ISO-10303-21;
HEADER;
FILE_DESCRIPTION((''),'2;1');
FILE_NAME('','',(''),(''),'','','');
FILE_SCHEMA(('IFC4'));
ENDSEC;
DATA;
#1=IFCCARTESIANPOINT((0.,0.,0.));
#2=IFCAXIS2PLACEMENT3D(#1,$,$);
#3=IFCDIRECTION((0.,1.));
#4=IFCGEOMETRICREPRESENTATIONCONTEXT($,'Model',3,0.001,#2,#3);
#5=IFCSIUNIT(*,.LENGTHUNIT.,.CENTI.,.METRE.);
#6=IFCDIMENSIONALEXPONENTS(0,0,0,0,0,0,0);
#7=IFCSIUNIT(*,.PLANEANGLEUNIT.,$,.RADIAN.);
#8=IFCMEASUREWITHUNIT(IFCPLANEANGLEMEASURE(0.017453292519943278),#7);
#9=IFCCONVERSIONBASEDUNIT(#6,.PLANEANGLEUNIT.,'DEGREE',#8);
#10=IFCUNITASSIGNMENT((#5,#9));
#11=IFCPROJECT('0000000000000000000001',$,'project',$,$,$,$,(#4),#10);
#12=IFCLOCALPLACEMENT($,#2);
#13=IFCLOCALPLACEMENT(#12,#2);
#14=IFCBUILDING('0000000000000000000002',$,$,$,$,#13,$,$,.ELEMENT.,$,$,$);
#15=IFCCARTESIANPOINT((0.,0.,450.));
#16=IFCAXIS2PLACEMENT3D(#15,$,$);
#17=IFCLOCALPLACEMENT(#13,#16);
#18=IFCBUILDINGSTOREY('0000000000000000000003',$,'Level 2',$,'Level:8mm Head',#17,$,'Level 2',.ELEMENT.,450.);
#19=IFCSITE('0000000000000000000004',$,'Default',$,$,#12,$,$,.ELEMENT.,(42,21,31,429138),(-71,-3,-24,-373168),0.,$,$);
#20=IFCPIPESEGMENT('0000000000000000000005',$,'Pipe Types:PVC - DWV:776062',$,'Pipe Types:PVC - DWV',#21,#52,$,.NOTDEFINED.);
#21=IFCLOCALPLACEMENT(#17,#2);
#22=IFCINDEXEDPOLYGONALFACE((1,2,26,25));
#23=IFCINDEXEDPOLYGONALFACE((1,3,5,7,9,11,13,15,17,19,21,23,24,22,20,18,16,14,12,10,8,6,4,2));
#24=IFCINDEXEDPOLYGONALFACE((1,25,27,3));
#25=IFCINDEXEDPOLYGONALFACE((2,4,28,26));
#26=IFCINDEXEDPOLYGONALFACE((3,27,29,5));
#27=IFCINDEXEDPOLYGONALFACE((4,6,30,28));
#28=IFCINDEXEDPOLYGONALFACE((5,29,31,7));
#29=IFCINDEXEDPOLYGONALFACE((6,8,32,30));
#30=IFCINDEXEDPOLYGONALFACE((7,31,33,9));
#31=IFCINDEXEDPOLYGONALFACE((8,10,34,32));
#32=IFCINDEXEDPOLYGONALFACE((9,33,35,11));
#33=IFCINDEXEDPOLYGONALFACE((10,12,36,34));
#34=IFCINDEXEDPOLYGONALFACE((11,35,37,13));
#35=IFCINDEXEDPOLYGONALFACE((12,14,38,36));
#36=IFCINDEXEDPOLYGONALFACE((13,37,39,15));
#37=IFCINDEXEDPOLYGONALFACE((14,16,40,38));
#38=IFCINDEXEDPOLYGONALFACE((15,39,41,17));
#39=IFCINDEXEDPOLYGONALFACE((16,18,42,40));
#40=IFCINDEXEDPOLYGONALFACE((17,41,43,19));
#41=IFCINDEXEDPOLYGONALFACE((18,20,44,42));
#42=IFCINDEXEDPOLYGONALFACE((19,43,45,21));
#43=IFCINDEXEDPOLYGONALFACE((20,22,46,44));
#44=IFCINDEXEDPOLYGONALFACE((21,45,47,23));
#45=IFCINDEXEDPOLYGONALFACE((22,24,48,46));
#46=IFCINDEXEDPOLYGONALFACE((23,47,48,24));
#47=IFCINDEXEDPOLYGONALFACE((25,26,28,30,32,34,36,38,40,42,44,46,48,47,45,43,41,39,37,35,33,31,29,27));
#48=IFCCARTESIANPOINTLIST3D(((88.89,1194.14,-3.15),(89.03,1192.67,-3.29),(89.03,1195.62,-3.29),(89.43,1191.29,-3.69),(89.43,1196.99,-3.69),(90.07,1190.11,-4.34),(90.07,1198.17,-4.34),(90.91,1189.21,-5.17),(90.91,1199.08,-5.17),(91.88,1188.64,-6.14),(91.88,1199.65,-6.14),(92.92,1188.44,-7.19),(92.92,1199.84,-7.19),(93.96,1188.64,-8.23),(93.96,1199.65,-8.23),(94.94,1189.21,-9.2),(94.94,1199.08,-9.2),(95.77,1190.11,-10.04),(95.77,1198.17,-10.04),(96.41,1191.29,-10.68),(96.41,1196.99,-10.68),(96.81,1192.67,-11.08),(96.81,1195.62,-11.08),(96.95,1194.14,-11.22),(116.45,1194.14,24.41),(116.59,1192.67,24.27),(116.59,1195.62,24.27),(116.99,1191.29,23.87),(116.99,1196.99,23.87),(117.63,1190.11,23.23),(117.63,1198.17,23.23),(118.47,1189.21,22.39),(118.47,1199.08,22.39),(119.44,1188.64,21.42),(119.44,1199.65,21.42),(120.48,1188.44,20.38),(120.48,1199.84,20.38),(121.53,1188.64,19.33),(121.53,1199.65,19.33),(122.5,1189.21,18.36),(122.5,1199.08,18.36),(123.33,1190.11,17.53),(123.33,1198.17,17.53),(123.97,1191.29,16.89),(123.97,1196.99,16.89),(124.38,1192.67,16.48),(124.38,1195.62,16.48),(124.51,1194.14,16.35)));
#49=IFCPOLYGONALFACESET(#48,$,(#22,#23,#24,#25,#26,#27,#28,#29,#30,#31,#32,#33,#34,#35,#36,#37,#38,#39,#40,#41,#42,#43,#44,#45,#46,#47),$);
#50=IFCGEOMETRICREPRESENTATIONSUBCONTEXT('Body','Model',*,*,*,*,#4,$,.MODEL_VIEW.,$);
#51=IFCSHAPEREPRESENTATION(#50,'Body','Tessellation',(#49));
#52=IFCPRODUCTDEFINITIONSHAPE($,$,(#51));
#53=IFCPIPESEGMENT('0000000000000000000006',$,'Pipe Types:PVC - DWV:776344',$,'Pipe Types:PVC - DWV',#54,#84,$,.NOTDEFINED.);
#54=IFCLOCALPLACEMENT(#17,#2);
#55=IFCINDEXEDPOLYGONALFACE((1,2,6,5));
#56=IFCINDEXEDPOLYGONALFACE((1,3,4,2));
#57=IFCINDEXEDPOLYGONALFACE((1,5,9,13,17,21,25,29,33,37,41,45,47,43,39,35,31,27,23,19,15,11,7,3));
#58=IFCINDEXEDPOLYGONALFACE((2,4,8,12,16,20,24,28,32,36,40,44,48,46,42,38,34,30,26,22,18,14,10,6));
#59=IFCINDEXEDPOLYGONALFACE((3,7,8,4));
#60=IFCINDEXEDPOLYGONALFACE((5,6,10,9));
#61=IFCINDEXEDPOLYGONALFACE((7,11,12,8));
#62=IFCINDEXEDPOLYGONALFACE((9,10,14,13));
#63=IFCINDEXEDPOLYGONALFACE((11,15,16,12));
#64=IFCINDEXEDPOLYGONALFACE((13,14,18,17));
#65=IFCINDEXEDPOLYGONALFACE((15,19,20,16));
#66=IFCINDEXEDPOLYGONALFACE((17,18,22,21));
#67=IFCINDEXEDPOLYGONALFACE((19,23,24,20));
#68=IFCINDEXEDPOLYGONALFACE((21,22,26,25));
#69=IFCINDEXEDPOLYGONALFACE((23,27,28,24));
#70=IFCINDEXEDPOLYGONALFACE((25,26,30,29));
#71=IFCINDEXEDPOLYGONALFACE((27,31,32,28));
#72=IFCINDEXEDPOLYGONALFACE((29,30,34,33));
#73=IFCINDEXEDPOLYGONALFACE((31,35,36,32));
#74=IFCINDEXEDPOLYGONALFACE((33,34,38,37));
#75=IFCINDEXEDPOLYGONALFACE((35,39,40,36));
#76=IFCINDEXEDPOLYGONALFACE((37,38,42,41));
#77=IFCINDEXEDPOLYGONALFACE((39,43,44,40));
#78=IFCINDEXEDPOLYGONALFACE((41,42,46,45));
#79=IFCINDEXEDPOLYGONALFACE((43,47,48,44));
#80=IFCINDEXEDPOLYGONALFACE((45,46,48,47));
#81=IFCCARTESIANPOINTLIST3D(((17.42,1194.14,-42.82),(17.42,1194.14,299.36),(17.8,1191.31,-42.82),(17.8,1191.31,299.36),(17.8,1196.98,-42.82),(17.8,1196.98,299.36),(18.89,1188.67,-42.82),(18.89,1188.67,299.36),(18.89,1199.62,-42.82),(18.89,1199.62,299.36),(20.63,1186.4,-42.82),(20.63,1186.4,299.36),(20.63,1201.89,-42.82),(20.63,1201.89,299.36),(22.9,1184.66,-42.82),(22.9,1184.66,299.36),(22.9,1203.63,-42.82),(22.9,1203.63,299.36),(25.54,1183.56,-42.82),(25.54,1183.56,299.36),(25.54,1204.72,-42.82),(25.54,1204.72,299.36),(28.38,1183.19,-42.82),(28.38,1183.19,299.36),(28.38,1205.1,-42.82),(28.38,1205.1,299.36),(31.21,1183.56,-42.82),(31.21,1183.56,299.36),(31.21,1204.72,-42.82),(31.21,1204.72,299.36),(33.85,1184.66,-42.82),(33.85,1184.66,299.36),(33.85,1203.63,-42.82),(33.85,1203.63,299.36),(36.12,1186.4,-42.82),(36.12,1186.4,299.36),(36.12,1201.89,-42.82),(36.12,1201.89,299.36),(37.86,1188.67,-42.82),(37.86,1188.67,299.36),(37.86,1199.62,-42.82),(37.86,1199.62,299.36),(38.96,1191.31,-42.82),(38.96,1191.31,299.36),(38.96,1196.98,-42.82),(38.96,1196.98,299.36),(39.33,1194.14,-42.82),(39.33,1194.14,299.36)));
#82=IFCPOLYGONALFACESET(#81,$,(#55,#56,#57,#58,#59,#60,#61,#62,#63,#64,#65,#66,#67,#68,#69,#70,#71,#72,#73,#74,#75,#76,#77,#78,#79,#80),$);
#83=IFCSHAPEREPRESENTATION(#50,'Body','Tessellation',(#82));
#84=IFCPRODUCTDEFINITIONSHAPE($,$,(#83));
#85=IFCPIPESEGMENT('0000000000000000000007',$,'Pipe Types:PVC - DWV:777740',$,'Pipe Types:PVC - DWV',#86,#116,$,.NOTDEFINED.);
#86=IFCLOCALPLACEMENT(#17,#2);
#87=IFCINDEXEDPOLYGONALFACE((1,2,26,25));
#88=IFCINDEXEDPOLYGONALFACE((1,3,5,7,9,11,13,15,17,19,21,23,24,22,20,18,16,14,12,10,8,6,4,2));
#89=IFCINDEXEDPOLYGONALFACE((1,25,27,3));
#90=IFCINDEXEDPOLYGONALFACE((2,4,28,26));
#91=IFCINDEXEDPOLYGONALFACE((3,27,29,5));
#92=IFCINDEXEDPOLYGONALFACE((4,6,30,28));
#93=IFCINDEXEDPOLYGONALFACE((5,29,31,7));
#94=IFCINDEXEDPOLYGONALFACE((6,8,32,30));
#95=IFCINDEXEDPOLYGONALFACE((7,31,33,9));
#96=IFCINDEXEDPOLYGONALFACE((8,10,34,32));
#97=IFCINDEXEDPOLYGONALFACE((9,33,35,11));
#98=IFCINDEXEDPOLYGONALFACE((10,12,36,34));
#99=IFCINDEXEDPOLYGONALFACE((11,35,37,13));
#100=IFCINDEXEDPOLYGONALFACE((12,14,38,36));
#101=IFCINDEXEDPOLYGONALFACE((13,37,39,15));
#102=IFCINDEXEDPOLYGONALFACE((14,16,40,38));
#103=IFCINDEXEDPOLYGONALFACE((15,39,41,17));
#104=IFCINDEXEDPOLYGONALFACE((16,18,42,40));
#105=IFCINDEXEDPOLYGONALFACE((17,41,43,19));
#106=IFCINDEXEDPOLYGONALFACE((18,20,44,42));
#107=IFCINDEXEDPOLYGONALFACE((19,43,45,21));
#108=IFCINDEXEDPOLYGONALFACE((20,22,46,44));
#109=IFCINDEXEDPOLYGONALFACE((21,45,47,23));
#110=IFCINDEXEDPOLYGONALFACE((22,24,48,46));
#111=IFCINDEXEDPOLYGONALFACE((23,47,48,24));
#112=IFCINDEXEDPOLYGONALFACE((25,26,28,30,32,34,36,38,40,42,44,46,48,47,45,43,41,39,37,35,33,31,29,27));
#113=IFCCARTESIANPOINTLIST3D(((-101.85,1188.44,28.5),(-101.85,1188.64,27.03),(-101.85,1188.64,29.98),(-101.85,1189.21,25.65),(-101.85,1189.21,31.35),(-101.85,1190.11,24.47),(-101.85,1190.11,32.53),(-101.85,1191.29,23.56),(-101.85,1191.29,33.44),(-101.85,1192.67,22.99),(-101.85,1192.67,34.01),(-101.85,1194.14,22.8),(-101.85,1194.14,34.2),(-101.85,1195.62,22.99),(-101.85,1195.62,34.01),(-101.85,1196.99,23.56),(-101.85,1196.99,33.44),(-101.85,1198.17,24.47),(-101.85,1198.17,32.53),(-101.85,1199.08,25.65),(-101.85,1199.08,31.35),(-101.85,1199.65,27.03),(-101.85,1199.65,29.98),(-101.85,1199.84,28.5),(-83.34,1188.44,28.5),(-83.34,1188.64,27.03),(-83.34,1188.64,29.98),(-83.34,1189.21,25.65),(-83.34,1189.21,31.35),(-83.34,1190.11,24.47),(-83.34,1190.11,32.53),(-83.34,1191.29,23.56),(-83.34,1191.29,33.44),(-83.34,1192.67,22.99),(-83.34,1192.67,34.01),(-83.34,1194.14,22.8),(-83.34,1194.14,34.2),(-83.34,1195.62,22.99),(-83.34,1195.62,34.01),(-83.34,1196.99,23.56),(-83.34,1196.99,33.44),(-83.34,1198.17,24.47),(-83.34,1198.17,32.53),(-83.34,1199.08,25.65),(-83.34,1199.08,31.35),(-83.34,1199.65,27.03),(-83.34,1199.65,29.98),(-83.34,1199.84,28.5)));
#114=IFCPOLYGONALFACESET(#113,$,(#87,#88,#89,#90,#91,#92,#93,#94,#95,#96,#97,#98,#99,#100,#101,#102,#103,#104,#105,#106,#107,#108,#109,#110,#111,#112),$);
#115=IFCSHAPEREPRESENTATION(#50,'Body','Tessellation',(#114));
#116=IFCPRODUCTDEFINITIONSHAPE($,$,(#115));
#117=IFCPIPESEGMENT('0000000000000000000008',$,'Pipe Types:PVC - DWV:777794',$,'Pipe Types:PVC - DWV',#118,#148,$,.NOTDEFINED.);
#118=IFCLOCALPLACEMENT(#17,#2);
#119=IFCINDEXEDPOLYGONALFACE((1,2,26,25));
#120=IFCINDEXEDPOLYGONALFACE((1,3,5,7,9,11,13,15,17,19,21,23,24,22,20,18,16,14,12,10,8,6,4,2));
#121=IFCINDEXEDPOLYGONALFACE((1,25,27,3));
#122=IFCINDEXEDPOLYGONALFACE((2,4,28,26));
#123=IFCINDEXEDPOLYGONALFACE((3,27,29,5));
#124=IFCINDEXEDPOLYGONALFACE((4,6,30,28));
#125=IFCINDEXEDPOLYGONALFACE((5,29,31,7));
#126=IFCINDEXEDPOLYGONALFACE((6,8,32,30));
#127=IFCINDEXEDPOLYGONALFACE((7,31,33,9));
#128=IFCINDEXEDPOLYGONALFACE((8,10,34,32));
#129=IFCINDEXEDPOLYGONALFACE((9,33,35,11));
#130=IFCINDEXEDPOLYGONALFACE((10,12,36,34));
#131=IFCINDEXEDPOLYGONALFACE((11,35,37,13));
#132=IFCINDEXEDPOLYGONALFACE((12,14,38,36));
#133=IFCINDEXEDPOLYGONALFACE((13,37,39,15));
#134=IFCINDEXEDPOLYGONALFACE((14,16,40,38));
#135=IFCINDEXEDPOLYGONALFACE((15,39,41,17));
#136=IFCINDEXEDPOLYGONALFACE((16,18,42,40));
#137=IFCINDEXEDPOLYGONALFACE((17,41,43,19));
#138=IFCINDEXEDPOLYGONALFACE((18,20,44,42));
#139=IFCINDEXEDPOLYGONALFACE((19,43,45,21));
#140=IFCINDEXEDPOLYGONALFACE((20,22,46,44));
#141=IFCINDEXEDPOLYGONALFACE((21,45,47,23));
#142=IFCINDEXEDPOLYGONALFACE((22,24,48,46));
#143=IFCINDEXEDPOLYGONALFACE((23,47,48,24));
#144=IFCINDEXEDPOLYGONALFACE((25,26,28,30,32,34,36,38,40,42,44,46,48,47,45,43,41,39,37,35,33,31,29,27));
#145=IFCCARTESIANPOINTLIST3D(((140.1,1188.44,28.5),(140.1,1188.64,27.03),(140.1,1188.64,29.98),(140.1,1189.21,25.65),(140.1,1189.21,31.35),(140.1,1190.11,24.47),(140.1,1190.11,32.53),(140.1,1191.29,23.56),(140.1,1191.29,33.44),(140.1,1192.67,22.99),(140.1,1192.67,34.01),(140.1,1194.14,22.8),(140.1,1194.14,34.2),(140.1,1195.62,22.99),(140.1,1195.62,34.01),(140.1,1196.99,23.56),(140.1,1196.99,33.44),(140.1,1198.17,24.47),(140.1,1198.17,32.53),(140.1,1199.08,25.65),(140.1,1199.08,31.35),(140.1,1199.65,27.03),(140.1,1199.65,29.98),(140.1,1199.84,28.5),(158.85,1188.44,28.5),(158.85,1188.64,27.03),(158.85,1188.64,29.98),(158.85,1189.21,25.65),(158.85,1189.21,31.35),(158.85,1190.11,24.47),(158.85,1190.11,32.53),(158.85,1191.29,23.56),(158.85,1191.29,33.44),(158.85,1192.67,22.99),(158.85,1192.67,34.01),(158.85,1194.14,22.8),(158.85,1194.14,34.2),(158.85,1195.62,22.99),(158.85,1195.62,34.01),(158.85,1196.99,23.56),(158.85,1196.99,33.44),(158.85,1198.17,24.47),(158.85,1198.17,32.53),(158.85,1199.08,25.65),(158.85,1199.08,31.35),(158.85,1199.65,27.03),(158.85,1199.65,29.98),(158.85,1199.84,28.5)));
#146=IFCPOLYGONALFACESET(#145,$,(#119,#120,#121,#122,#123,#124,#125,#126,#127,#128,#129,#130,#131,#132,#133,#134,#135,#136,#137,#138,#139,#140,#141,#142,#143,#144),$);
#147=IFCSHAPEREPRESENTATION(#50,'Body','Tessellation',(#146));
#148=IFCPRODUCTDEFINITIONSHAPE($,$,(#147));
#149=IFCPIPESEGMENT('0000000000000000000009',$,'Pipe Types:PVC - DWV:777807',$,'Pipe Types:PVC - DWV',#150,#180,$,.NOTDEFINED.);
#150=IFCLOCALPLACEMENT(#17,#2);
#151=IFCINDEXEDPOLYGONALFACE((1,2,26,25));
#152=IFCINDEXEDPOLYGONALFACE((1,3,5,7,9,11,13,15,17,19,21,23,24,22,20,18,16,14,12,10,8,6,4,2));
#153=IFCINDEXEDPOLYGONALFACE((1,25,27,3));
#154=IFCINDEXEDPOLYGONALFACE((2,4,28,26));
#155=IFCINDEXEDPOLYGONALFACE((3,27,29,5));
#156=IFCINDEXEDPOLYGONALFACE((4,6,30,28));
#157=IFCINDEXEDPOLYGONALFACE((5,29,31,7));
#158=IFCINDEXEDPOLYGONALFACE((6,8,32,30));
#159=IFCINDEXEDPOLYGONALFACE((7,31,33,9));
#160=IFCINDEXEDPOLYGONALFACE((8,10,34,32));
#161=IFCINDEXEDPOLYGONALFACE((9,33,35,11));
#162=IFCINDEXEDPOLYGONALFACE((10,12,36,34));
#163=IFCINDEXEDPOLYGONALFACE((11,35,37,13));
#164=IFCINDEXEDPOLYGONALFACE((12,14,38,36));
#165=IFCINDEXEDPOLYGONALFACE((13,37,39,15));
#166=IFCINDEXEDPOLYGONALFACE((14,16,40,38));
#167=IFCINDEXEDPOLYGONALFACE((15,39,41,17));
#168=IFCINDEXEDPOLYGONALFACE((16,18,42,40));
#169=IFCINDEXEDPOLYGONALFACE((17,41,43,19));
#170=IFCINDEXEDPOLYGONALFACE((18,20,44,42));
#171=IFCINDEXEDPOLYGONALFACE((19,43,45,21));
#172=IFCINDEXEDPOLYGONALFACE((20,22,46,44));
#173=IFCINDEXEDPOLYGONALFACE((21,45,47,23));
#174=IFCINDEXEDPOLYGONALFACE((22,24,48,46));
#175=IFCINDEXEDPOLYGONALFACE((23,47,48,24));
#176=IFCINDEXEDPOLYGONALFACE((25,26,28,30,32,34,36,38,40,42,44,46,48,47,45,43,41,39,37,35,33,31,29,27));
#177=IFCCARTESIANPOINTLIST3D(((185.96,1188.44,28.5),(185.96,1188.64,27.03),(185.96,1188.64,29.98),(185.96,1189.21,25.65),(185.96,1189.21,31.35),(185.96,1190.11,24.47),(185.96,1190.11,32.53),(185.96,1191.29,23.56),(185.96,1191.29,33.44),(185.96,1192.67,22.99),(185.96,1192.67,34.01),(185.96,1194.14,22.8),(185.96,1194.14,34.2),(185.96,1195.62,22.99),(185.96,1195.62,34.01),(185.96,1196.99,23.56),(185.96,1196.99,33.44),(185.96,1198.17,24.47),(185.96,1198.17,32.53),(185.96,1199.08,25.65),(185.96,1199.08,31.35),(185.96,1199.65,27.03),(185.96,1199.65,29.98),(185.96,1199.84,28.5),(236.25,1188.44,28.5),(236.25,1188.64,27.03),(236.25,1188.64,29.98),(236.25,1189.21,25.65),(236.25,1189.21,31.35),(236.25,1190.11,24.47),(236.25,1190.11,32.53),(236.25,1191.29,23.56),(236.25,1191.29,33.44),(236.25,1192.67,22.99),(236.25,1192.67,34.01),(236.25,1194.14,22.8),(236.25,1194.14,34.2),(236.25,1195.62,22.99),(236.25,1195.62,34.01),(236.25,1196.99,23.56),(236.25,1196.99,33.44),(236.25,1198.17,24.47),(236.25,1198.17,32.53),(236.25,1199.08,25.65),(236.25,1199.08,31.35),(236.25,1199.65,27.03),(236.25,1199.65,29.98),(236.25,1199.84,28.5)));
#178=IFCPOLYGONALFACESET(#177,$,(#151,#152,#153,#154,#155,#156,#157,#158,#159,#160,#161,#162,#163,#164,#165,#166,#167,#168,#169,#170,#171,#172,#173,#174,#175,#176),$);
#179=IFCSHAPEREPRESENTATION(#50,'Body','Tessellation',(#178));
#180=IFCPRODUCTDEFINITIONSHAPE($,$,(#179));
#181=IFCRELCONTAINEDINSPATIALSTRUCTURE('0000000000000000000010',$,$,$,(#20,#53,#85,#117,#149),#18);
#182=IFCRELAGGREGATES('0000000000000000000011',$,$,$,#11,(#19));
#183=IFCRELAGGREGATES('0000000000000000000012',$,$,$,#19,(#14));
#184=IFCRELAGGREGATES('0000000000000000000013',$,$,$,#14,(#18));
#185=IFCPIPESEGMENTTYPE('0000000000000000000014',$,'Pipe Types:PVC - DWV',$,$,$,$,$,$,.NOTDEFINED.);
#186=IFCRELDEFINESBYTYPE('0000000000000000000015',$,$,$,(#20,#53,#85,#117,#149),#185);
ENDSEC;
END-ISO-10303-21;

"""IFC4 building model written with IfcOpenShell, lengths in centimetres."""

from ifc_helpers import new_model, entity, si_unit, converted_unit, direction, frame, origin, place, context, subcontext, project, spatial, arc, indexed_curve, outline, extrude, type_object, element, save


model = new_model("IFC4")

# Units and contexts
model_context = context("Model", 3, precision=0.001, world=origin(), true_north=direction((0.0, 1.0)))
body_context = subcontext(model_context, "Body", "Model", "MODEL_VIEW")
ifc_project = project(units=[si_unit("LENGTHUNIT", "METRE", prefix="CENTI"), converted_unit("PLANEANGLEUNIT", "DEGREE", entity("IfcPlaneAngleMeasure", 0.017453292519943278), si_unit("PLANEANGLEUNIT", "RADIAN"), dimensions=[0, 0, 0, 0, 0, 0, 0])], contexts=[model_context])

# Site, building, storey
site_placement = place(None, origin())
site = spatial("IfcSite", under=ifc_project, at=site_placement, Name="Default", CompositionType="ELEMENT", RefLatitude=(42, 21, 31, 429138), RefLongitude=(-71, -3, -24, -373168), RefElevation=0.0)
building_placement = place(site_placement, origin())
building = spatial("IfcBuilding", under=site, at=building_placement, CompositionType="ELEMENT")
storey_placement = place(building_placement, frame((0.0, 0.0, 450.0)))
storey = spatial("IfcBuildingStorey", under=building, at=storey_placement, Name="Level 2", ObjectType="Level:8mm Head", LongName="Level 2", CompositionType="ELEMENT", Elevation=450.0)

# Pipe segments
pipe_segment_type = type_object("IfcPipeSegmentType", Name="Pipe Types:PVC - DWV", PredefinedType="NOTDEFINED")
pipe_segment_1_placement = place(storey_placement, origin())
element("IfcPipeSegment", 1, at=pipe_segment_1_placement, inside=storey, type_object=pipe_segment_type, Name="Pipe Types:PVC - DWV:776062", ObjectType="Pipe Types:PVC - DWV", PredefinedType="NOTDEFINED", context=body_context, shape_type="SweptSolid", body=[
    extrude(outline(indexed_curve([(5.7, 0.0), (4.03, 4.03), (0.0, 5.7), (-4.03, 4.03), (-5.7, 0.0), (-4.03, -4.03), (0.0, -5.7), (4.03, -4.03)], segments=[arc(1, 2, 3), arc(3, 4, 5), arc(5, 6, 7), arc(7, 8, 1)], self_intersect=False)), frame((92.92, 1194.14, -7.19), z_axis=(0.707107, 0.0, 0.707107), x_axis=(0.0, -1.0, 0.0)), (0.0, 0.0, 1.0), 38.98),
])
pipe_segment_2_placement = place(storey_placement, origin())
element("IfcPipeSegment", 2, at=pipe_segment_2_placement, inside=storey, type_object=pipe_segment_type, Name="Pipe Types:PVC - DWV:776344", ObjectType="Pipe Types:PVC - DWV", PredefinedType="NOTDEFINED", context=body_context, shape_type="SweptSolid", body=[
    extrude(outline(indexed_curve([(10.95, 0.0), (7.75, 7.75), (0.0, 10.95), (-7.75, 7.75), (-10.95, 0.0), (-7.75, -7.75), (0.0, -10.95), (7.75, -7.75)], segments=[arc(1, 2, 3), arc(3, 4, 5), arc(5, 6, 7), arc(7, 8, 1)], self_intersect=False)), frame((28.38, 1194.14, -42.82)), (0.0, 0.0, 1.0), 342.18),
])
pipe_segment_3_placement = place(storey_placement, origin())
element("IfcPipeSegment", 3, at=pipe_segment_3_placement, inside=storey, type_object=pipe_segment_type, Name="Pipe Types:PVC - DWV:777740", ObjectType="Pipe Types:PVC - DWV", PredefinedType="NOTDEFINED", context=body_context, shape_type="SweptSolid", body=[
    extrude(outline(indexed_curve([(5.7, 0.0), (4.03, 4.03), (0.0, 5.7), (-4.03, 4.03), (-5.7, 0.0), (-4.03, -4.03), (0.0, -5.7), (4.03, -4.03)], segments=[arc(1, 2, 3), arc(3, 4, 5), arc(5, 6, 7), arc(7, 8, 1)], self_intersect=False)), frame((-101.85, 1194.14, 28.5), z_axis=(1.0, 0.0, 0.0), x_axis=(0.0, 1.0, 0.0)), (0.0, 0.0, 1.0), 18.51),
])
pipe_segment_4_placement = place(storey_placement, origin())
element("IfcPipeSegment", 4, at=pipe_segment_4_placement, inside=storey, type_object=pipe_segment_type, Name="Pipe Types:PVC - DWV:777794", ObjectType="Pipe Types:PVC - DWV", PredefinedType="NOTDEFINED", context=body_context, shape_type="SweptSolid", body=[
    extrude(outline(indexed_curve([(5.7, 0.0), (4.03, 4.03), (0.0, 5.7), (-4.03, 4.03), (-5.7, 0.0), (-4.03, -4.03), (0.0, -5.7), (4.03, -4.03)], segments=[arc(1, 2, 3), arc(3, 4, 5), arc(5, 6, 7), arc(7, 8, 1)], self_intersect=False)), frame((140.1, 1194.14, 28.5), z_axis=(1.0, 0.0, 0.0), x_axis=(0.0, 1.0, 0.0)), (0.0, 0.0, 1.0), 18.76),
])
pipe_segment_5_placement = place(storey_placement, origin())
element("IfcPipeSegment", 5, at=pipe_segment_5_placement, inside=storey, type_object=pipe_segment_type, Name="Pipe Types:PVC - DWV:777807", ObjectType="Pipe Types:PVC - DWV", PredefinedType="NOTDEFINED", context=body_context, shape_type="SweptSolid", body=[
    extrude(outline(indexed_curve([(5.7, 0.0), (4.03, 4.03), (0.0, 5.7), (-4.03, 4.03), (-5.7, 0.0), (-4.03, -4.03), (0.0, -5.7), (4.03, -4.03)], segments=[arc(1, 2, 3), arc(3, 4, 5), arc(5, 6, 7), arc(7, 8, 1)], self_intersect=False)), frame((185.96, 1194.14, 28.5), z_axis=(1.0, 0.0, 0.0), x_axis=(0.0, 1.0, 0.0)), (0.0, 0.0, 1.0), 50.29),
])

save(model, "model.ifc")
